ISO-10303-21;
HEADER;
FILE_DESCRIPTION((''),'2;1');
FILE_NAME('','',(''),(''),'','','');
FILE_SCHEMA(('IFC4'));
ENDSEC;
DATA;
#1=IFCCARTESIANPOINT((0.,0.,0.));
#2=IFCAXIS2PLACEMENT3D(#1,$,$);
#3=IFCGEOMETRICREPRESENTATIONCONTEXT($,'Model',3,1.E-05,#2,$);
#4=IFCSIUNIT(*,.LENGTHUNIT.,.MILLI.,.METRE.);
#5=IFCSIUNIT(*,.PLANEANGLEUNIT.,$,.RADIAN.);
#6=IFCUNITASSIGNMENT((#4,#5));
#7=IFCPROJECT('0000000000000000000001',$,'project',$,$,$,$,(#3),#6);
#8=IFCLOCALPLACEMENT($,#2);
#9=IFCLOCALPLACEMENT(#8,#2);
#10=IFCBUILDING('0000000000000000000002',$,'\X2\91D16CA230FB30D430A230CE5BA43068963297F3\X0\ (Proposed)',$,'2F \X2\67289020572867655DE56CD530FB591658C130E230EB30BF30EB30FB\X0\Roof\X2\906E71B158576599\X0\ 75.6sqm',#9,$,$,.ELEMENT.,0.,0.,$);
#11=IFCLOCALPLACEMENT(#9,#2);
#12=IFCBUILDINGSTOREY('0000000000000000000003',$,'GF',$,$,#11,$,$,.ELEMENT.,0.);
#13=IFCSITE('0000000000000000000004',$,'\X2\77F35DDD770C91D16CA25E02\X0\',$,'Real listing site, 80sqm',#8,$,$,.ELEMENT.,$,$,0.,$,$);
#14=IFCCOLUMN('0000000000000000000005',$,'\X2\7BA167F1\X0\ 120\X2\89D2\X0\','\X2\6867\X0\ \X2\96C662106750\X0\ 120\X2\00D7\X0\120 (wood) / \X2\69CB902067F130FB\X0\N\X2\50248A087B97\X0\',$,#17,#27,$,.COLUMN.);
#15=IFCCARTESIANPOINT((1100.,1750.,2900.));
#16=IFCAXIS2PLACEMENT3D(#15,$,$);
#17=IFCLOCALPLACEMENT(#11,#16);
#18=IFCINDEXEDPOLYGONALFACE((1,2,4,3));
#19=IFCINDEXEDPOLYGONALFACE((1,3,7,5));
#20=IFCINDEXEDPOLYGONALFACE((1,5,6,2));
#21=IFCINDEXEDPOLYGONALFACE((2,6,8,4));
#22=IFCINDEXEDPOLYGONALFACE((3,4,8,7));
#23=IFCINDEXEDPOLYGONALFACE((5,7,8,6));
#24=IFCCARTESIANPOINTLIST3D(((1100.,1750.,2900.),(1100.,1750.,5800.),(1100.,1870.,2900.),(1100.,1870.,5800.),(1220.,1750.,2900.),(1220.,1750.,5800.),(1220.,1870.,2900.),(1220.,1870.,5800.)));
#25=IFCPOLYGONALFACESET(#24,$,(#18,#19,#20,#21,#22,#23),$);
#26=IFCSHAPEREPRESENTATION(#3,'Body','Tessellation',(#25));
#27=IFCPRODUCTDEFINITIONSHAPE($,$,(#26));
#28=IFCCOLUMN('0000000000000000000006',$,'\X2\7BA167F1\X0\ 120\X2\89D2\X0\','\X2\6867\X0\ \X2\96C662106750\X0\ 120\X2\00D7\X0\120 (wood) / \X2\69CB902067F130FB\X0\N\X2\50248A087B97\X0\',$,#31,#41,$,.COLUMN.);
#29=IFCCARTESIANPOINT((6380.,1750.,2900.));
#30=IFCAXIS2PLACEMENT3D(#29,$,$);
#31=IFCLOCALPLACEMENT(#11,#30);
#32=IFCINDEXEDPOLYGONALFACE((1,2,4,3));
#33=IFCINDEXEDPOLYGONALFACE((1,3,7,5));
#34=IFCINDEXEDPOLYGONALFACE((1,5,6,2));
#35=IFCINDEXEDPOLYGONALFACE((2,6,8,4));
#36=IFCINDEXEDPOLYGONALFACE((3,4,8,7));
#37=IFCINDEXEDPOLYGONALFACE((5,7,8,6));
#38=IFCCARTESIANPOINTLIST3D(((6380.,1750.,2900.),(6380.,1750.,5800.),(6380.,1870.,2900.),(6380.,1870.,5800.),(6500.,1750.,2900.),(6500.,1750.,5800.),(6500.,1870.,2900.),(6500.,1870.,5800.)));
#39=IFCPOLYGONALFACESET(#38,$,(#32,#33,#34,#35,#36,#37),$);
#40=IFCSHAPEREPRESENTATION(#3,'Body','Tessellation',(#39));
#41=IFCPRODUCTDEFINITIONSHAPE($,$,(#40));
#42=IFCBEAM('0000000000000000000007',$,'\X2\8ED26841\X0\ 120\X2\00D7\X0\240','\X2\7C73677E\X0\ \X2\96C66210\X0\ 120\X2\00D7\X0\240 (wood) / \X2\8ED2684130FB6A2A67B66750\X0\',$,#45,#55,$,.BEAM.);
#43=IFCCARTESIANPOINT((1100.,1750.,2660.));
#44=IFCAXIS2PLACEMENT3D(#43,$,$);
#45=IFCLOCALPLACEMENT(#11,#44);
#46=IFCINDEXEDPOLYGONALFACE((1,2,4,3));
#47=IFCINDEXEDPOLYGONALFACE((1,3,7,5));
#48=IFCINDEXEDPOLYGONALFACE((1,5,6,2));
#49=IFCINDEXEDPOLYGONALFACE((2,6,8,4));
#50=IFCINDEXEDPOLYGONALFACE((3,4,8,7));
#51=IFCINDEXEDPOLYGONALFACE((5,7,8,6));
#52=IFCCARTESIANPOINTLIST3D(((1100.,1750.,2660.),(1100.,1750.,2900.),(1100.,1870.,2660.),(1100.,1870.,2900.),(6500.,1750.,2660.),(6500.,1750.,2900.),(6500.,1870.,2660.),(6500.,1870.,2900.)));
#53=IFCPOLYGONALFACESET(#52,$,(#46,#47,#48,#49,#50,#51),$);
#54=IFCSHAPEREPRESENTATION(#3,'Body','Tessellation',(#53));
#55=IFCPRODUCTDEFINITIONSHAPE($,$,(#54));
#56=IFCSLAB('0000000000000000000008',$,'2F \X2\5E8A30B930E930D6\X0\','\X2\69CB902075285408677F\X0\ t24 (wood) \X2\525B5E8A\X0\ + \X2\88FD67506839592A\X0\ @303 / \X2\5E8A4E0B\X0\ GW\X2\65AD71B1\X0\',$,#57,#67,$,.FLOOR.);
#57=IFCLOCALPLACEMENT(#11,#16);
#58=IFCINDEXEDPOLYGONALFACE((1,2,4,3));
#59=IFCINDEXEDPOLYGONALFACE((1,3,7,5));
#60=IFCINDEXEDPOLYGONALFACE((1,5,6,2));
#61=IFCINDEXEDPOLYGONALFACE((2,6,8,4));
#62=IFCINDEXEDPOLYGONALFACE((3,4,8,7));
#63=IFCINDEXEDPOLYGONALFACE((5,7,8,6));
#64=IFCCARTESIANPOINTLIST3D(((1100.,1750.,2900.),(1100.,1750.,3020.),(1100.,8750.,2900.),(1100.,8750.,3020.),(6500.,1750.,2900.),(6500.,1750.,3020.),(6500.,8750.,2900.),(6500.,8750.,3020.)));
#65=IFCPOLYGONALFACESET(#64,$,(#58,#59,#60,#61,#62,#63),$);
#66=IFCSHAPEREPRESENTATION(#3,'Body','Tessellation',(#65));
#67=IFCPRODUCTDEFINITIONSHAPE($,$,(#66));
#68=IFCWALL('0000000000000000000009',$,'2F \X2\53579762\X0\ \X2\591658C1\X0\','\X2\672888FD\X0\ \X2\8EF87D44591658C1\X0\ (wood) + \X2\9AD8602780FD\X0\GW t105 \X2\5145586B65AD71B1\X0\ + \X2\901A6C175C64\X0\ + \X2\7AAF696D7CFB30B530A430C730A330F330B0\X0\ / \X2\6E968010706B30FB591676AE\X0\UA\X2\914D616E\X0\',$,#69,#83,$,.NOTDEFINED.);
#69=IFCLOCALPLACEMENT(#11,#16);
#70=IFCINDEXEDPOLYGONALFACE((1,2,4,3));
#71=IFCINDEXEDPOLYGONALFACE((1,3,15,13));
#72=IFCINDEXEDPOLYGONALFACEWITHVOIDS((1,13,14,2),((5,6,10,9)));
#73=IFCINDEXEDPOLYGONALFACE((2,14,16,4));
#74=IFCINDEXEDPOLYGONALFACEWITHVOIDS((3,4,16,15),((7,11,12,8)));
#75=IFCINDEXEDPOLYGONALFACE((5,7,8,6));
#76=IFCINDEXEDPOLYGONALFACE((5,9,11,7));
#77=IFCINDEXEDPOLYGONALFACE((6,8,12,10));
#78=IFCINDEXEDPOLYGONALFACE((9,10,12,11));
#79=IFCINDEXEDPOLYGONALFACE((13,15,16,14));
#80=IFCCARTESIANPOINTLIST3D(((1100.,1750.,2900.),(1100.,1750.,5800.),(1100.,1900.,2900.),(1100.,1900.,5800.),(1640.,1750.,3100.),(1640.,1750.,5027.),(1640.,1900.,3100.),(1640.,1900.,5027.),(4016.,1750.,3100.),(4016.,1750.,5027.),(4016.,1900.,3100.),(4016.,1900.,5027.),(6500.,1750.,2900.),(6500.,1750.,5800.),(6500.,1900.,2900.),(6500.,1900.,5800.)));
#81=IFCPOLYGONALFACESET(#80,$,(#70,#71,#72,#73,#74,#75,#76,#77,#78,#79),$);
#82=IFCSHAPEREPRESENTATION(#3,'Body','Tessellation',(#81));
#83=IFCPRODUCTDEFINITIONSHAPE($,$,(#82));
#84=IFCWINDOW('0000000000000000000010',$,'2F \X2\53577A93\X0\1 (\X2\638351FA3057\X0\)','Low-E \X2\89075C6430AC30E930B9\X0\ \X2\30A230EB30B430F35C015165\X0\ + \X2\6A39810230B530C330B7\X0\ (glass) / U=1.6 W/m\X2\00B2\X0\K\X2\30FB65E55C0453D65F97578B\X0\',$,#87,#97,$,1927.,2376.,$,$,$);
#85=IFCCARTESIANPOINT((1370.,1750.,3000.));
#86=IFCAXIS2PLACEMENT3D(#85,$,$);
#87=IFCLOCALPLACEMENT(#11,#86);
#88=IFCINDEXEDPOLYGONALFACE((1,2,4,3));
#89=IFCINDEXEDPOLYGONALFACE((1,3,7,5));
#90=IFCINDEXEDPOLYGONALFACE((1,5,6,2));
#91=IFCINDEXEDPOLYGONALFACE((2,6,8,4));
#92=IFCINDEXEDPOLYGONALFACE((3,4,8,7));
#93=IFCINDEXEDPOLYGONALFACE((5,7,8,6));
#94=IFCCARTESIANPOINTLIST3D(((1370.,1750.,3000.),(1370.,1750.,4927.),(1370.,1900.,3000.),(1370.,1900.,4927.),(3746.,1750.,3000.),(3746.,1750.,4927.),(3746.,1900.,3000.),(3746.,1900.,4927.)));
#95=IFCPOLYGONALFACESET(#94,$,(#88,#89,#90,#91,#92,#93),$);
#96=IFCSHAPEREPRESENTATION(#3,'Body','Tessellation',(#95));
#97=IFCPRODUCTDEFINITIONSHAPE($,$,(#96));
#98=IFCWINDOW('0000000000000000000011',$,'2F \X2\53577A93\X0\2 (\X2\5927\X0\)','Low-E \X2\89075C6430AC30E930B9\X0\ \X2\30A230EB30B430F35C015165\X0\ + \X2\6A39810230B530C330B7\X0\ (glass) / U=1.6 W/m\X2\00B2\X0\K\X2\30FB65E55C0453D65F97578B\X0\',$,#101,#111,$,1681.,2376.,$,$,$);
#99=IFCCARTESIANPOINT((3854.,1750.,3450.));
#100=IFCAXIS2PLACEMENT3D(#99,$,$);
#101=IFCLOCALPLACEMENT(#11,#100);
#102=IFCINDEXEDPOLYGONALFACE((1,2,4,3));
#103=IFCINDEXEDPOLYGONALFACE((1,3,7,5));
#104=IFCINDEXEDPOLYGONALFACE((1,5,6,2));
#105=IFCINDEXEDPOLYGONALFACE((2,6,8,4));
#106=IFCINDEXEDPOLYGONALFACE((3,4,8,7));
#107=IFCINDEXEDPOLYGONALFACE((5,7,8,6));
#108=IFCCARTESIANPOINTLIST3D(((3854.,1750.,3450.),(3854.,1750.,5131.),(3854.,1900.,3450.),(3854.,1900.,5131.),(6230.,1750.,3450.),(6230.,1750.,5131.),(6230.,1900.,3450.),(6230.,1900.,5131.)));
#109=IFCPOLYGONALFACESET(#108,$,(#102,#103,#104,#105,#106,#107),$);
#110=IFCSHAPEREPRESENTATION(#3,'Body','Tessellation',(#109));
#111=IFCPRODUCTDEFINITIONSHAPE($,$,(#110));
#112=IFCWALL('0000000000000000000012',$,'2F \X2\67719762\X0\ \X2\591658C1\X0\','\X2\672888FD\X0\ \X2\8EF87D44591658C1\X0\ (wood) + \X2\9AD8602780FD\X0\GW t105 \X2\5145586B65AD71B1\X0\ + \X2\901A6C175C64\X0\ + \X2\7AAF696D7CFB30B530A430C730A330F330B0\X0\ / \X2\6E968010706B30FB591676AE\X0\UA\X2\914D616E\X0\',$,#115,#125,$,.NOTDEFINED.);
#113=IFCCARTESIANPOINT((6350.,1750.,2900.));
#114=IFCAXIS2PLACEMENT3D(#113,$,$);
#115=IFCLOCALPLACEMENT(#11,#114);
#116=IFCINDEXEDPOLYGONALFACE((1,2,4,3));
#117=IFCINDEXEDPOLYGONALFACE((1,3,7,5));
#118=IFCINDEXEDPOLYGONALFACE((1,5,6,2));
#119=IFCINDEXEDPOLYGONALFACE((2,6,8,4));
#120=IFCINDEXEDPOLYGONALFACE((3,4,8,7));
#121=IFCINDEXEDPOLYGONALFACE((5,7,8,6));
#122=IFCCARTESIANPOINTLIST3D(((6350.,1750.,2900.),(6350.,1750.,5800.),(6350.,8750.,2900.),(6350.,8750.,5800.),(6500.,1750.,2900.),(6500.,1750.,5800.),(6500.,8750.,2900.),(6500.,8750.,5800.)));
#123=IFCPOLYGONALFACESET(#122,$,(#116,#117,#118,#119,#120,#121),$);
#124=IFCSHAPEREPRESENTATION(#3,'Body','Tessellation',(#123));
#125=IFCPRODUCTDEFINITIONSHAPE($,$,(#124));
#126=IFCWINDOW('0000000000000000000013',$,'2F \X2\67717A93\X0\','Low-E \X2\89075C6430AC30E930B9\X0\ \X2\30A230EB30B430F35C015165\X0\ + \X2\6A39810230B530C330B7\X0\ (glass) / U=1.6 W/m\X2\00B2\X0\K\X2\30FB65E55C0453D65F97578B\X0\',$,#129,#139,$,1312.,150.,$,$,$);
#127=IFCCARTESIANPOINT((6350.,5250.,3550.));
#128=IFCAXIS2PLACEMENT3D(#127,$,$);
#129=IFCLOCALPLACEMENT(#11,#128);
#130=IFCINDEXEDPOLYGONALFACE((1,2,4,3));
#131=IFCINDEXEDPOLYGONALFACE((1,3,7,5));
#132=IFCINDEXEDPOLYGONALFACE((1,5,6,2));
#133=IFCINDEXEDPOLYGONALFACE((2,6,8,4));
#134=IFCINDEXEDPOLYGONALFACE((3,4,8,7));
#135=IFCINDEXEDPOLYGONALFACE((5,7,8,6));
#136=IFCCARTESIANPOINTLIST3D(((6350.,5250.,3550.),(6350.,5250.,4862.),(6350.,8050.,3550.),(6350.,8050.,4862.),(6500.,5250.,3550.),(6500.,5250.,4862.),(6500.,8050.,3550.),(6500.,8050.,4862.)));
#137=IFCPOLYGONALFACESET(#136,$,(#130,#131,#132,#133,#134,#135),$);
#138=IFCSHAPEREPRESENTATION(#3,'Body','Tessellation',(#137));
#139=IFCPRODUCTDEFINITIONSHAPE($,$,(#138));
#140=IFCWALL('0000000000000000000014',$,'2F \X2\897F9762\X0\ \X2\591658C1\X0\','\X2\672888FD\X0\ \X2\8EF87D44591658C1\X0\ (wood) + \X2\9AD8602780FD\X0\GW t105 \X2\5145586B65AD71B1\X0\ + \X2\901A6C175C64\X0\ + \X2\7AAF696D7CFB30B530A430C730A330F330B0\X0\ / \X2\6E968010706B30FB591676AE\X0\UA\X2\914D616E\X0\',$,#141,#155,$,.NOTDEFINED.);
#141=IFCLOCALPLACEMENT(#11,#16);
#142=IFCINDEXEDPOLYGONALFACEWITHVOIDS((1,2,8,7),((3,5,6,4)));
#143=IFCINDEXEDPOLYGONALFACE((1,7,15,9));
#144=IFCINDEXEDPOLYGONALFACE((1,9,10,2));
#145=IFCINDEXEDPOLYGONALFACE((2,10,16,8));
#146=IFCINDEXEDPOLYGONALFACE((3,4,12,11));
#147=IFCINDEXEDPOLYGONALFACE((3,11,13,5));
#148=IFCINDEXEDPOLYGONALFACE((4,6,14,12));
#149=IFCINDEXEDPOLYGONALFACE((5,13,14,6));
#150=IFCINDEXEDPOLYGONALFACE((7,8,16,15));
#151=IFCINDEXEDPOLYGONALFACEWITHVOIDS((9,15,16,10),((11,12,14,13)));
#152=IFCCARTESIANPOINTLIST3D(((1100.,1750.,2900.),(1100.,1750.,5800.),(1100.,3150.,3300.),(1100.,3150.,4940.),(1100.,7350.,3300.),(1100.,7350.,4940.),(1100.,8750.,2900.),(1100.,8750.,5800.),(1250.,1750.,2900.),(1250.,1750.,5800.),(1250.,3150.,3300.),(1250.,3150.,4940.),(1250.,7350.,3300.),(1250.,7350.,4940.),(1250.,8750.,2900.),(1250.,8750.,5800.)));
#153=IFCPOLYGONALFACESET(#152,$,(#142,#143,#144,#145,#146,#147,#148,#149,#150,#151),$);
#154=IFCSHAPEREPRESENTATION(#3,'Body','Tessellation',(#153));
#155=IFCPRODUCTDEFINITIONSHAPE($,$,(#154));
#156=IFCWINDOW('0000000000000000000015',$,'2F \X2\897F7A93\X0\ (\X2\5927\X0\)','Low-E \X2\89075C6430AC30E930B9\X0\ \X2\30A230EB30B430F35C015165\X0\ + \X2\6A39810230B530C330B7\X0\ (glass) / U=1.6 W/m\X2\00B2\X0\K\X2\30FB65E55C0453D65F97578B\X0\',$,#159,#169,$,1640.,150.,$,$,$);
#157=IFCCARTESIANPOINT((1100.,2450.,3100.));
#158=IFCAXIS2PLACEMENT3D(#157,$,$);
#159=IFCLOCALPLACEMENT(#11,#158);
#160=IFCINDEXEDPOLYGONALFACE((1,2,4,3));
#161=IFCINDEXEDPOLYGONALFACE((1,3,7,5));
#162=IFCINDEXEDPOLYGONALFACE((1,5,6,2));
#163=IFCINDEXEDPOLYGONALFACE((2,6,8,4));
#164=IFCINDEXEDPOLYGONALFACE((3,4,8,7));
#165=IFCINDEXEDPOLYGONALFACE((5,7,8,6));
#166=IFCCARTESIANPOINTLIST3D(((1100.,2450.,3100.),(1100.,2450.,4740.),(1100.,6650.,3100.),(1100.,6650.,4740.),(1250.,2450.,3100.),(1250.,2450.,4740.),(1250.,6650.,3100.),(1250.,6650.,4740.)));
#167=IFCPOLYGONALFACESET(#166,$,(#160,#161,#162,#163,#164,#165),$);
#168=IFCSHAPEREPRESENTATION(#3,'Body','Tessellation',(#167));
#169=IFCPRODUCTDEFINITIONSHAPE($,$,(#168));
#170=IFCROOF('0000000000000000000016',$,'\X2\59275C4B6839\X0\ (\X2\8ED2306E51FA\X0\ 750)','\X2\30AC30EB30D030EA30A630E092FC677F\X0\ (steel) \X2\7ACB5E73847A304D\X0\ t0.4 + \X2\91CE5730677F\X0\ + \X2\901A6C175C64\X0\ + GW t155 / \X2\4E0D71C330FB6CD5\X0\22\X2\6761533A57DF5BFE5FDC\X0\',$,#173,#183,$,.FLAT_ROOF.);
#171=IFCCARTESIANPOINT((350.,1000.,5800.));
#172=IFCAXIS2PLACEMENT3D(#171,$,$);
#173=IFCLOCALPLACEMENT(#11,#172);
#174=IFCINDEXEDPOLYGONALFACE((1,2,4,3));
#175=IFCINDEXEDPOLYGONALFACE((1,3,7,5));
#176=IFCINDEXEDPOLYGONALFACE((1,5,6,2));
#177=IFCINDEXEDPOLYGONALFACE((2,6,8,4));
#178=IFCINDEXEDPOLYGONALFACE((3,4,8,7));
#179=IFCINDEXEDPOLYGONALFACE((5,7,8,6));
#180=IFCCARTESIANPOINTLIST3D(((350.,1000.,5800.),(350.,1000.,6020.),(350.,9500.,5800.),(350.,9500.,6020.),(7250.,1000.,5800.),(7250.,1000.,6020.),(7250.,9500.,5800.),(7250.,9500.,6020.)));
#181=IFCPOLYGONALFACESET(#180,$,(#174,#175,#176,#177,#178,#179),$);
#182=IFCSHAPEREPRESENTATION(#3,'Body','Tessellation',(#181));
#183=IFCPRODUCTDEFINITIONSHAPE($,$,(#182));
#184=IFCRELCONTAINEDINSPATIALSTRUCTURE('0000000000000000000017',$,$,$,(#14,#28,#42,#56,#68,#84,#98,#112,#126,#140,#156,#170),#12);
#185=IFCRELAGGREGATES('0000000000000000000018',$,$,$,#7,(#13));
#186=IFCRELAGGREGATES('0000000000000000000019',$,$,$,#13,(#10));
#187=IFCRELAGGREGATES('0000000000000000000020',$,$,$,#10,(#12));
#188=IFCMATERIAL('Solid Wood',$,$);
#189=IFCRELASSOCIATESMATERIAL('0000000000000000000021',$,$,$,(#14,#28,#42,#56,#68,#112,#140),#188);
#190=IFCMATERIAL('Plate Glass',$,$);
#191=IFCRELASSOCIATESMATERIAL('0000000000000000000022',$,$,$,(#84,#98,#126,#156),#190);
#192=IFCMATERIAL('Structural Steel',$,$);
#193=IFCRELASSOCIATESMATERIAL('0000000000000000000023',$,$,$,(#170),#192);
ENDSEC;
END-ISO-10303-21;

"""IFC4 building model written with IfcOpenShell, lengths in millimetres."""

from ifc_helpers import new_model, si_unit, frame, frame_2d, origin, place, context, project, spatial, rectangle, extrude, material, element, fill, save


model = new_model("IFC4")

# Units and contexts
model_context = context("Model", 3, precision=1e-05, world=origin())
ifc_project = project(units=[si_unit("LENGTHUNIT", "METRE", prefix="MILLI"), si_unit("PLANEANGLEUNIT", "RADIAN")], contexts=[model_context])

# Site, building, storey
site_placement = place(None, origin())
site = spatial("IfcSite", under=ifc_project, at=site_placement, Name="石川県金沢市", ObjectType="Real listing site, 80sqm", CompositionType="ELEMENT", RefElevation=0.0)
building_placement = place(site_placement, origin())
building = spatial("IfcBuilding", under=site, at=building_placement, Name="金沢・ピアノ室と防音 (Proposed)", ObjectType="2F 木造在来工法・外壁モルタル・Roof遮熱塗料 75.6sqm", CompositionType="ELEMENT", ElevationOfRefHeight=0.0, ElevationOfTerrain=0.0)
storey_placement = place(building_placement, origin())
storey = spatial("IfcBuildingStorey", under=building, at=storey_placement, Name="GF", CompositionType="ELEMENT", Elevation=0.0)

# Columns
ifc_material_1 = material(Name="Solid Wood")
column_1_placement = place(storey_placement, frame((1100.0, 1750.0, 2900.0)))
element("IfcColumn", 1, at=column_1_placement, inside=storey, material=ifc_material_1, Name="管柱 120角", Description="桧 集成材 120×120 (wood) / 構造柱・N値計算", PredefinedType="COLUMN", context=model_context, shape_type="SweptSolid", body=[
    extrude(rectangle(XDim=120.0, YDim=120.0, at=frame_2d((60.0, 60.0))), frame((1100.0, 1750.0, 2900.0)), (0.0, 0.0, 1.0), 2900.0),
])
column_2_placement = place(storey_placement, frame((6380.0, 1750.0, 2900.0)))
element("IfcColumn", 2, at=column_2_placement, inside=storey, material=ifc_material_1, Name="管柱 120角", Description="桧 集成材 120×120 (wood) / 構造柱・N値計算", PredefinedType="COLUMN", context=model_context, shape_type="SweptSolid", body=[
    extrude(rectangle(XDim=120.0, YDim=120.0, at=frame_2d((60.0, 60.0))), frame((6380.0, 1750.0, 2900.0)), (0.0, 0.0, 1.0), 2900.0),
])

# Beam
beam_1_placement = place(storey_placement, frame((1100.0, 1750.0, 2660.0)))
element("IfcBeam", 3, at=beam_1_placement, inside=storey, material=ifc_material_1, Name="軒桁 120×240", Description="米松 集成 120×240 (wood) / 軒桁・横架材", PredefinedType="BEAM", context=model_context, shape_type="SweptSolid", body=[
    extrude(rectangle(XDim=5400.0, YDim=120.0, at=frame_2d((2700.0, 60.0))), frame((1100.0, 1750.0, 2660.0)), (0.0, 0.0, 1.0), 240.0),
])

# Slab
slab_placement = place(storey_placement, frame((1100.0, 1750.0, 2900.0)))
element("IfcSlab", 4, at=slab_placement, inside=storey, material=ifc_material_1, Name="2F 床スラブ", Description="構造用合板 t24 (wood) 剛床 + 製材根太 @303 / 床下 GW断熱", PredefinedType="FLOOR", context=model_context, shape_type="SweptSolid", body=[
    extrude(rectangle(XDim=5400.0, YDim=7000.0, at=frame_2d((2700.0, 3500.0))), frame((1100.0, 1750.0, 2900.0)), (0.0, 0.0, 1.0), 120.0),
])

# Wall, openings, windows
wall_1_placement = place(storey_placement, frame((1100.0, 1750.0, 2900.0)))
wall_1 = element("IfcWall", 5, at=wall_1_placement, inside=storey, material=ifc_material_1, Name="2F 南面 外壁", Description="木製 軸組外壁 (wood) + 高性能GW t105 充填断熱 + 通気層 + 窯業系サイディング / 準耐火・外皮UA配慮", PredefinedType="NOTDEFINED", context=model_context, shape_type="SweptSolid", body=[
    extrude(rectangle(XDim=5400.0, YDim=150.0, at=frame_2d((2700.0, 75.0))), frame((1100.0, 1750.0, 2900.0)), (0.0, 0.0, 1.0), 2900.0),
])
opening_1_placement = place(storey_placement, frame((1370.0, 1750.0, 3000.0)))
opening_1 = element("IfcOpeningElement", 6, at=opening_1_placement, cuts=wall_1, PredefinedType="NOTDEFINED", context=model_context, shape_type="SweptSolid", body=[
    extrude(rectangle(XDim=2376.0, YDim=150.0, at=frame_2d((1188.0, 75.0))), frame((1370.0, 1750.0, 3000.0)), (0.0, 0.0, 1.0), 1927.0),
])
opening_2_placement = place(storey_placement, frame((3854.0, 1750.0, 3450.0)))
opening_2 = element("IfcOpeningElement", 7, at=opening_2_placement, cuts=wall_1, PredefinedType="NOTDEFINED", context=model_context, shape_type="SweptSolid", body=[
    extrude(rectangle(XDim=2376.0, YDim=150.0, at=frame_2d((1188.0, 75.0))), frame((3854.0, 1750.0, 3450.0)), (0.0, 0.0, 1.0), 1681.0),
])
ifc_material_2 = material(Name="Plate Glass")
window_1_placement = place(storey_placement, frame((1370.0, 1750.0, 3000.0)))
window_1 = element("IfcWindow", 8, at=window_1_placement, inside=storey, material=ifc_material_2, Name="2F 南窓1 (掃出し)", Description="Low-E 複層ガラス アルゴン封入 + 樹脂サッシ (glass) / U=1.6 W/m²K・日射取得型", OverallHeight=1927.0, OverallWidth=2376.0, context=model_context, shape_type="SweptSolid", body=[
    extrude(rectangle(XDim=2376.0, YDim=150.0, at=frame_2d((1188.0, 75.0))), frame((1370.0, 1750.0, 3000.0)), (0.0, 0.0, 1.0), 1927.0),
])
fill(opening_1, window_1)
window_2_placement = place(storey_placement, frame((3854.0, 1750.0, 3450.0)))
window_2 = element("IfcWindow", 9, at=window_2_placement, inside=storey, material=ifc_material_2, Name="2F 南窓2 (大)", Description="Low-E 複層ガラス アルゴン封入 + 樹脂サッシ (glass) / U=1.6 W/m²K・日射取得型", OverallHeight=1681.0, OverallWidth=2376.0, context=model_context, shape_type="SweptSolid", body=[
    extrude(rectangle(XDim=2376.0, YDim=150.0, at=frame_2d((1188.0, 75.0))), frame((3854.0, 1750.0, 3450.0)), (0.0, 0.0, 1.0), 1681.0),
])
fill(opening_2, window_2)

# Walls, openings, windows
wall_2_placement = place(storey_placement, frame((6350.0, 1750.0, 2900.0)))
wall_2 = element("IfcWall", 10, at=wall_2_placement, inside=storey, material=ifc_material_1, Name="2F 東面 外壁", Description="木製 軸組外壁 (wood) + 高性能GW t105 充填断熱 + 通気層 + 窯業系サイディング / 準耐火・外皮UA配慮", PredefinedType="NOTDEFINED", context=model_context, shape_type="SweptSolid", body=[
    extrude(rectangle(XDim=150.0, YDim=7000.0, at=frame_2d((75.0, 3500.0))), frame((6350.0, 1750.0, 2900.0)), (0.0, 0.0, 1.0), 2900.0),
])
opening_3_placement = place(storey_placement, frame((6350.0, 5250.0, 3550.0)))
opening_3 = element("IfcOpeningElement", 11, at=opening_3_placement, cuts=wall_2, PredefinedType="NOTDEFINED", context=model_context, shape_type="SweptSolid", body=[
    extrude(rectangle(XDim=150.0, YDim=2800.0, at=frame_2d((75.0, 1400.0))), frame((6350.0, 5250.0, 3550.0)), (0.0, 0.0, 1.0), 1312.0),
])
window_3_placement = place(storey_placement, frame((6350.0, 5250.0, 3550.0)))
window_3 = element("IfcWindow", 12, at=window_3_placement, inside=storey, material=ifc_material_2, Name="2F 東窓", Description="Low-E 複層ガラス アルゴン封入 + 樹脂サッシ (glass) / U=1.6 W/m²K・日射取得型", OverallHeight=1312.0, OverallWidth=150.0, context=model_context, shape_type="SweptSolid", body=[
    extrude(rectangle(XDim=150.0, YDim=2800.0, at=frame_2d((75.0, 1400.0))), frame((6350.0, 5250.0, 3550.0)), (0.0, 0.0, 1.0), 1312.0),
])
fill(opening_3, window_3)
wall_3_placement = place(storey_placement, frame((1100.0, 1750.0, 2900.0)))
wall_3 = element("IfcWall", 13, at=wall_3_placement, inside=storey, material=ifc_material_1, Name="2F 西面 外壁", Description="木製 軸組外壁 (wood) + 高性能GW t105 充填断熱 + 通気層 + 窯業系サイディング / 準耐火・外皮UA配慮", PredefinedType="NOTDEFINED", context=model_context, shape_type="SweptSolid", body=[
    extrude(rectangle(XDim=150.0, YDim=7000.0, at=frame_2d((75.0, 3500.0))), frame((1100.0, 1750.0, 2900.0)), (0.0, 0.0, 1.0), 2900.0),
])
opening_4_placement = place(storey_placement, frame((1100.0, 2450.0, 3100.0)))
opening_4 = element("IfcOpeningElement", 14, at=opening_4_placement, cuts=wall_3, PredefinedType="NOTDEFINED", context=model_context, shape_type="SweptSolid", body=[
    extrude(rectangle(XDim=150.0, YDim=4200.0, at=frame_2d((75.0, 2100.0))), frame((1100.0, 2450.0, 3100.0)), (0.0, 0.0, 1.0), 1640.0),
])
window_4_placement = place(storey_placement, frame((1100.0, 2450.0, 3100.0)))
window_4 = element("IfcWindow", 15, at=window_4_placement, inside=storey, material=ifc_material_2, Name="2F 西窓 (大)", Description="Low-E 複層ガラス アルゴン封入 + 樹脂サッシ (glass) / U=1.6 W/m²K・日射取得型", OverallHeight=1640.0, OverallWidth=150.0, context=model_context, shape_type="SweptSolid", body=[
    extrude(rectangle(XDim=150.0, YDim=4200.0, at=frame_2d((75.0, 2100.0))), frame((1100.0, 2450.0, 3100.0)), (0.0, 0.0, 1.0), 1640.0),
])
fill(opening_4, window_4)

# Roof
ifc_material_3 = material(Name="Structural Steel")
roof_placement = place(storey_placement, frame((350.0, 1000.0, 5800.0)))
element("IfcRoof", 16, at=roof_placement, inside=storey, material=ifc_material_3, Name="大屋根 (軒の出 750)", Description="ガルバリウム鋼板 (steel) 立平葺き t0.4 + 野地板 + 通気層 + GW t155 / 不燃・法22条区域対応", PredefinedType="FLAT_ROOF", context=model_context, shape_type="SweptSolid", body=[
    extrude(rectangle(XDim=6900.0, YDim=8500.0, at=frame_2d((3450.0, 4250.0))), frame((350.0, 1000.0, 5800.0)), (0.0, 0.0, 1.0), 220.0),
])

save(model, "model.ifc")
